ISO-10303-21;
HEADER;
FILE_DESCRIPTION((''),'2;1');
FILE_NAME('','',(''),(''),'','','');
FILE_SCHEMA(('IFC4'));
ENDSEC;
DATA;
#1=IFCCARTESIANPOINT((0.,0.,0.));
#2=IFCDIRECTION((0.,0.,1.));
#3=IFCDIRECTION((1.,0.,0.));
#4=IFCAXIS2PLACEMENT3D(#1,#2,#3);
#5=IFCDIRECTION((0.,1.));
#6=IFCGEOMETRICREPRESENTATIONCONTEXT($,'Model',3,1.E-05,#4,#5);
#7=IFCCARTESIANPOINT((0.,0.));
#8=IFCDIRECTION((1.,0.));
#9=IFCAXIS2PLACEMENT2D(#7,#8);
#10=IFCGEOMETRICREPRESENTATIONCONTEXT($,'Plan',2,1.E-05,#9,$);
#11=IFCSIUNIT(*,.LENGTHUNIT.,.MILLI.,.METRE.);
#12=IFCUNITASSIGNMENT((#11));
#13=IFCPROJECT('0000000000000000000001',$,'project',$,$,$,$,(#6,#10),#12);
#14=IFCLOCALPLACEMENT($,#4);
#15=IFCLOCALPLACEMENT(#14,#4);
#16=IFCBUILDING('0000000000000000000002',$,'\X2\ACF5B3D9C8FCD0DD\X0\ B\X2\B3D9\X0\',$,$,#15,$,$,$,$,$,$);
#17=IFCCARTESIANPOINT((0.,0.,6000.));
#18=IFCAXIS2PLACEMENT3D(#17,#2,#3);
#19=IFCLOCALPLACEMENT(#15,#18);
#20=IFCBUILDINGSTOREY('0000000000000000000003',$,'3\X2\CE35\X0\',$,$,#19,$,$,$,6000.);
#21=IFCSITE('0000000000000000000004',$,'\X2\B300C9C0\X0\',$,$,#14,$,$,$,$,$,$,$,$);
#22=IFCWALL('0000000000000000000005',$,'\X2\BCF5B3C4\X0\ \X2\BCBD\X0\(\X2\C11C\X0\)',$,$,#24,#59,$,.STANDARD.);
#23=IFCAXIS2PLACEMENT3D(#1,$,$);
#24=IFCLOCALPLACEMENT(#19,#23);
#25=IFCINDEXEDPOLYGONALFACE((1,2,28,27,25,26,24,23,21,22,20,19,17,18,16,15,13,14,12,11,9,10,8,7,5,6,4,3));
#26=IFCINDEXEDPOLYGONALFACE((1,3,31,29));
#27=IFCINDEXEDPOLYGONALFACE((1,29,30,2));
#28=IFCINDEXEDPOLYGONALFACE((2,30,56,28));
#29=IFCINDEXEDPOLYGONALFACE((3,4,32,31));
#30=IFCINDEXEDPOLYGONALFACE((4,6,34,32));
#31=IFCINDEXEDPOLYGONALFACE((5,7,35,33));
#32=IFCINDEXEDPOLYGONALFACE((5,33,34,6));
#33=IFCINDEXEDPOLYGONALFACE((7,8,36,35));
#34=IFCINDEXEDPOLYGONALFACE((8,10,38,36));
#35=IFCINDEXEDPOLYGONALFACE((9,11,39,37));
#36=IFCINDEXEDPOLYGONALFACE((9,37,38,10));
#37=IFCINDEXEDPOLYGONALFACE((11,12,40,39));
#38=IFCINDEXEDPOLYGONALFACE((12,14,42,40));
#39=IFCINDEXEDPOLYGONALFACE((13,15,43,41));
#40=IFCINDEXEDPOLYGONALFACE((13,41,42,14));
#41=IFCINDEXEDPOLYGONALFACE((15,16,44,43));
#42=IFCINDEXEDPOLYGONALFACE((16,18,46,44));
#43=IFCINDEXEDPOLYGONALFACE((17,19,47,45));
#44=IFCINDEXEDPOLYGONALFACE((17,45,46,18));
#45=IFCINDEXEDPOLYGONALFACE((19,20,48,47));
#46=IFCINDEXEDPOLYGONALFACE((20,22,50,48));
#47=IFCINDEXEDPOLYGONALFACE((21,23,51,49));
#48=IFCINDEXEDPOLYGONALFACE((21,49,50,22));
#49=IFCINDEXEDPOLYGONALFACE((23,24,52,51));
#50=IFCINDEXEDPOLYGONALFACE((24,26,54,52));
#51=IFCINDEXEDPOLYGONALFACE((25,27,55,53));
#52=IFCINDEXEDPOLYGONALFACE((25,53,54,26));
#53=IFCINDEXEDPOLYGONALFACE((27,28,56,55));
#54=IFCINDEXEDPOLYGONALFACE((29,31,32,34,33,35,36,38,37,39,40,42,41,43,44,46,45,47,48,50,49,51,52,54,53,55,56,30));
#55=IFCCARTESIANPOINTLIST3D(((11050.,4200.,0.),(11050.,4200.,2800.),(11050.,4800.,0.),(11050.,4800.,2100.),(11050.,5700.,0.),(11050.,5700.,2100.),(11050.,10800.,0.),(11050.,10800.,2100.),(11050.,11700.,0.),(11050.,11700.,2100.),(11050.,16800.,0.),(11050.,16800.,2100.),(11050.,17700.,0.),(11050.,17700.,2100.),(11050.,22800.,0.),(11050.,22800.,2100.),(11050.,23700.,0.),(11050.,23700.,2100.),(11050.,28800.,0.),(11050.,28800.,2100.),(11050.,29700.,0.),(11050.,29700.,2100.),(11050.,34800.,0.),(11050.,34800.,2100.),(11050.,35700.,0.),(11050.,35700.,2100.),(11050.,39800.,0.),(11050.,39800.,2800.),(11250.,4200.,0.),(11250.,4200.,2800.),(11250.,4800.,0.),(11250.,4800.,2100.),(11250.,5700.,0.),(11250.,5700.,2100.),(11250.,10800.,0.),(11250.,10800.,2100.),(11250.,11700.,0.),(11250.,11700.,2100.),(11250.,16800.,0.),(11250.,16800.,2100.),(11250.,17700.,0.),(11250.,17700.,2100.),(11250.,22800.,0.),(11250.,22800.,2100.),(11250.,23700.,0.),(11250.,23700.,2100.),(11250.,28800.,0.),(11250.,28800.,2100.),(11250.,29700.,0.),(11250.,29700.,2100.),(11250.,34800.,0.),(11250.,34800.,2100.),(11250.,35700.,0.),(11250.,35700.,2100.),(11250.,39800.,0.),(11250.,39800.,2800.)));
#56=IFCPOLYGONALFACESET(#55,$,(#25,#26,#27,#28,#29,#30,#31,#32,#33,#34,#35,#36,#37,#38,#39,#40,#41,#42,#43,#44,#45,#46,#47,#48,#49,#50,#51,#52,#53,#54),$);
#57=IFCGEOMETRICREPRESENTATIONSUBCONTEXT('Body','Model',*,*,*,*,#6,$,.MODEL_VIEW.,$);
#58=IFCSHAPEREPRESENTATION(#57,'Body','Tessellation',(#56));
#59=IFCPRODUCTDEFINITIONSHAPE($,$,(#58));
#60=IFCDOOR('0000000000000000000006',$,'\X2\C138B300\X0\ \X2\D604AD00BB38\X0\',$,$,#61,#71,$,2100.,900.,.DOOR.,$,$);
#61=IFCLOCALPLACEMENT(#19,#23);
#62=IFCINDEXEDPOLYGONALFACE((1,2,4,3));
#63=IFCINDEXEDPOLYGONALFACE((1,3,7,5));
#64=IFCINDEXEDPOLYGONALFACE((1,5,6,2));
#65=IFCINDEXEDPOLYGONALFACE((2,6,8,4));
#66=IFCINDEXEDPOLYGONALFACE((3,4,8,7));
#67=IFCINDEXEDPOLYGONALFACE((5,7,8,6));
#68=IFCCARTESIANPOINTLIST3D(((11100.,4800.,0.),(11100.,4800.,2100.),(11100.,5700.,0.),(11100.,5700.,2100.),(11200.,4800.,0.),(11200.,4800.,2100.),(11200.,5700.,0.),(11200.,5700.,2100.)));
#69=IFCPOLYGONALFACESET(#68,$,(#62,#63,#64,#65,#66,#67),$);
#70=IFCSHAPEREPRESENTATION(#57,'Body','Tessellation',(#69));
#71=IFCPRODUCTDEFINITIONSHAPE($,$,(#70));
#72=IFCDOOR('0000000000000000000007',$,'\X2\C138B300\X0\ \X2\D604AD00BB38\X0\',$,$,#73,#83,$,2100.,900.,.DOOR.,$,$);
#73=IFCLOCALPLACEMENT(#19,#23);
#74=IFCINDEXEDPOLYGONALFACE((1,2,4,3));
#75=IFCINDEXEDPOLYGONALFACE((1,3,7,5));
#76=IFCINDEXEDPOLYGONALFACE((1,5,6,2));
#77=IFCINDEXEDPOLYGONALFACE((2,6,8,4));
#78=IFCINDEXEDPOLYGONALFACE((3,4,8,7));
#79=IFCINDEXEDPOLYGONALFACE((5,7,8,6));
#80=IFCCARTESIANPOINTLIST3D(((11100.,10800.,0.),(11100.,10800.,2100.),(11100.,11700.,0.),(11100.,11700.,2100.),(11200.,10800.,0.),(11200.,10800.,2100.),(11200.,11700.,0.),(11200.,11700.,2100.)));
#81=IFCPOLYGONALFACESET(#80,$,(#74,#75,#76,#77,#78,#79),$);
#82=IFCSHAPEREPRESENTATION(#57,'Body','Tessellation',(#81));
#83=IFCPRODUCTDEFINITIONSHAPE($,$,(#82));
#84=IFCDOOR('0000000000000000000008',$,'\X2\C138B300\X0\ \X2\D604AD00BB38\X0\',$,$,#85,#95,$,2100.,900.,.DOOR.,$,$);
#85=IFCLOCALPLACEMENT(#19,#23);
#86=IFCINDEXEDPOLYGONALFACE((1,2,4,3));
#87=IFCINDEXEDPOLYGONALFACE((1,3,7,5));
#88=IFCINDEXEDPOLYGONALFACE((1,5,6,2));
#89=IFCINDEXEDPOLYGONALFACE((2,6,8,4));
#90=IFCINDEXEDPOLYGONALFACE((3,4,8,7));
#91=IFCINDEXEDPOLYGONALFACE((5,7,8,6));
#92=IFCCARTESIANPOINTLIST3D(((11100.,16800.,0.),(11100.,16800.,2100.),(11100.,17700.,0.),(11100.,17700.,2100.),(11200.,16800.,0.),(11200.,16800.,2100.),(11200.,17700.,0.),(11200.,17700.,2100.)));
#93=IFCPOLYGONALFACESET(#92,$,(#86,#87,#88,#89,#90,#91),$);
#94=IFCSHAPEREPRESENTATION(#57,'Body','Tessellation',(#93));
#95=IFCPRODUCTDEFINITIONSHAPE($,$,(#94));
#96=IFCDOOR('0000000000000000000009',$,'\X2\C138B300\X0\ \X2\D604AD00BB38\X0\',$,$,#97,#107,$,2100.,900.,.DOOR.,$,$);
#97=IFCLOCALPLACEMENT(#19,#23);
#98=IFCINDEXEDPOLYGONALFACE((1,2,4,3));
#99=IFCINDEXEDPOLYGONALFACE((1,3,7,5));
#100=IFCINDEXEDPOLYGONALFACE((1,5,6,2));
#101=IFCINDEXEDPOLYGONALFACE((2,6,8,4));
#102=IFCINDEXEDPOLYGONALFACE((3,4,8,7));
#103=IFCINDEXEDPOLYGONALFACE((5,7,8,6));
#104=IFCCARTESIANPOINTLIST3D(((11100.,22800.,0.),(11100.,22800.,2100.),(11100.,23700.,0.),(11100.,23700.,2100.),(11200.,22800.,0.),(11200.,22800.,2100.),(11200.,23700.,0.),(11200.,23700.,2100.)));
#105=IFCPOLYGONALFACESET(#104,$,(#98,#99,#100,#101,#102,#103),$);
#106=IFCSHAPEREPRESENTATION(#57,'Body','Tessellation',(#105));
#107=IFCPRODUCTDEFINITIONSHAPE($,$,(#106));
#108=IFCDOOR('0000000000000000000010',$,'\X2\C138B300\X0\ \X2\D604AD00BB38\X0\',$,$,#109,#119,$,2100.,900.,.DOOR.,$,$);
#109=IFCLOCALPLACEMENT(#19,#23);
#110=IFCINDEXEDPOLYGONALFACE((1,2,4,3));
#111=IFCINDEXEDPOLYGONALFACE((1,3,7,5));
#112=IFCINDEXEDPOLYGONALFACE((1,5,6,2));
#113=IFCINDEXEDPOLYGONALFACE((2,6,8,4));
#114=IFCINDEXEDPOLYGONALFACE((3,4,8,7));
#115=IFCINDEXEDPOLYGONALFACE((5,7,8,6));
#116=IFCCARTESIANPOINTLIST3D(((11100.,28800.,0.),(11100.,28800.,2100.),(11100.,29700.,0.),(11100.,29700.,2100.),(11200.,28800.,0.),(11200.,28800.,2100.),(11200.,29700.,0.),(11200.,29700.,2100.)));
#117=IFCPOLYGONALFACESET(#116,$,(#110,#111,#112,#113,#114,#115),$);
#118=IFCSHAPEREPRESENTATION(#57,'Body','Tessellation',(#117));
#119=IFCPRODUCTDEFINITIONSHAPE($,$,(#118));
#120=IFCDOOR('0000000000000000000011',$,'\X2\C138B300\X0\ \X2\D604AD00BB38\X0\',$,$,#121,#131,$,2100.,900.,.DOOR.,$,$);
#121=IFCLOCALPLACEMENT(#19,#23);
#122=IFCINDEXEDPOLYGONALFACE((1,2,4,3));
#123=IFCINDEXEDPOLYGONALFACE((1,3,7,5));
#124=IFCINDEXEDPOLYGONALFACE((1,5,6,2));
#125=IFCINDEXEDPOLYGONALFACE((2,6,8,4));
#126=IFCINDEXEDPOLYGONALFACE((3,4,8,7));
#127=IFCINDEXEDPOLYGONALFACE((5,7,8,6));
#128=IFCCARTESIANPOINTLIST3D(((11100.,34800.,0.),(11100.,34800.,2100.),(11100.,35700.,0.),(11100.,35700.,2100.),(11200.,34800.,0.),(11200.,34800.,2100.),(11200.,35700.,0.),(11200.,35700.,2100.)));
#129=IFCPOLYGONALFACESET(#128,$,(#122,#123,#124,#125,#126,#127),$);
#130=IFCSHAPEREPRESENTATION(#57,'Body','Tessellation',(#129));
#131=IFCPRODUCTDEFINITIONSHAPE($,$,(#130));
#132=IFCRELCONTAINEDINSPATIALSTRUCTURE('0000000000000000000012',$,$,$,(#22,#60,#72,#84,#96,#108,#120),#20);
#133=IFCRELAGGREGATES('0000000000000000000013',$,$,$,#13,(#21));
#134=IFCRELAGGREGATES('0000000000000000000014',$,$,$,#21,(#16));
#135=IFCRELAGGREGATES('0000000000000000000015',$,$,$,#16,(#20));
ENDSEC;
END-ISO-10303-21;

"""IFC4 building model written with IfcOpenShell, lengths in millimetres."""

from ifc_helpers import new_model, si_unit, direction, frame, origin_with_axes, origin_2d_with_axis, place, context, subcontext, project, spatial, polyline, outline, extrude, element, fill, save


model = new_model("IFC4")

# Units and contexts
model_context = context("Model", 3, precision=1e-05, world=origin_with_axes(), true_north=direction((0.0, 1.0)))
plan_context = context("Plan", 2, precision=1e-05, world=origin_2d_with_axis())
body_context = subcontext(model_context, "Body", "Model", "MODEL_VIEW")
ifc_project = project(units=[si_unit("LENGTHUNIT", "METRE", prefix="MILLI")], contexts=[model_context, plan_context])

# Site, building, storey
site_placement = place(None, origin_with_axes())
site = spatial("IfcSite", under=ifc_project, at=site_placement, Name="대지")
building_placement = place(site_placement, origin_with_axes())
building = spatial("IfcBuilding", under=site, at=building_placement, Name="공동주택 B동")
storey_placement = place(building_placement, frame((0.0, 0.0, 6000.0), z_axis=(0.0, 0.0, 1.0), x_axis=(1.0, 0.0, 0.0)))
storey = spatial("IfcBuildingStorey", under=building, at=storey_placement, Name="3층", Elevation=6000.0)

# Wall, openings, doors
wall_1_placement = place(storey_placement, origin_with_axes())
wall_1 = element("IfcWall", 1, at=wall_1_placement, inside=storey, Name="복도 벽(서)", PredefinedType="STANDARD", context=body_context, shape_type="SweptSolid", body=[
    extrude(outline(polyline([(11050.0, 4200.0), (11050.0, 39800.0), (11250.0, 39800.0), (11250.0, 4200.0), (11050.0, 4200.0)])), origin_with_axes(), (0.0, 0.0, 1.0), 2800.0),
])
opening_1_placement = place(storey_placement, origin_with_axes())
opening_1 = element("IfcOpeningElement", 2, at=opening_1_placement, cuts=wall_1, PredefinedType="OPENING", context=body_context, shape_type="SweptSolid", body=[
    extrude(outline(polyline([(11300.0, 4800.0), (11300.0, 5700.0), (11000.0, 5700.0), (11000.0, 4800.0), (11300.0, 4800.0)])), origin_with_axes(), (0.0, 0.0, 1.0), 2100.0),
])
opening_2_placement = place(storey_placement, origin_with_axes())
opening_2 = element("IfcOpeningElement", 3, at=opening_2_placement, cuts=wall_1, PredefinedType="OPENING", context=body_context, shape_type="SweptSolid", body=[
    extrude(outline(polyline([(11300.0, 10800.0), (11300.0, 11700.0), (11000.0, 11700.0), (11000.0, 10800.0), (11300.0, 10800.0)])), origin_with_axes(), (0.0, 0.0, 1.0), 2100.0),
])
opening_3_placement = place(storey_placement, origin_with_axes())
opening_3 = element("IfcOpeningElement", 4, at=opening_3_placement, cuts=wall_1, PredefinedType="OPENING", context=body_context, shape_type="SweptSolid", body=[
    extrude(outline(polyline([(11300.0, 16800.0), (11300.0, 17700.0), (11000.0, 17700.0), (11000.0, 16800.0), (11300.0, 16800.0)])), origin_with_axes(), (0.0, 0.0, 1.0), 2100.0),
])
opening_4_placement = place(storey_placement, origin_with_axes())
opening_4 = element("IfcOpeningElement", 5, at=opening_4_placement, cuts=wall_1, PredefinedType="OPENING", context=body_context, shape_type="SweptSolid", body=[
    extrude(outline(polyline([(11300.0, 22800.0), (11300.0, 23700.0), (11000.0, 23700.0), (11000.0, 22800.0), (11300.0, 22800.0)])), origin_with_axes(), (0.0, 0.0, 1.0), 2100.0),
])
opening_5_placement = place(storey_placement, origin_with_axes())
opening_5 = element("IfcOpeningElement", 6, at=opening_5_placement, cuts=wall_1, PredefinedType="OPENING", context=body_context, shape_type="SweptSolid", body=[
    extrude(outline(polyline([(11300.0, 28800.0), (11300.0, 29700.0), (11000.0, 29700.0), (11000.0, 28800.0), (11300.0, 28800.0)])), origin_with_axes(), (0.0, 0.0, 1.0), 2100.0),
])
opening_6_placement = place(storey_placement, origin_with_axes())
opening_6 = element("IfcOpeningElement", 7, at=opening_6_placement, cuts=wall_1, PredefinedType="OPENING", context=body_context, shape_type="SweptSolid", body=[
    extrude(outline(polyline([(11300.0, 34800.0), (11300.0, 35700.0), (11000.0, 35700.0), (11000.0, 34800.0), (11300.0, 34800.0)])), origin_with_axes(), (0.0, 0.0, 1.0), 2100.0),
])
door_1_placement = place(storey_placement, origin_with_axes())
door_1 = element("IfcDoor", 8, at=door_1_placement, inside=storey, Name="세대 현관문", OverallHeight=2100.0, OverallWidth=900.0, PredefinedType="DOOR", context=body_context, shape_type="SweptSolid", body=[
    extrude(outline(polyline([(11200.0, 4800.0), (11200.0, 5700.0), (11100.0, 5700.0), (11100.0, 4800.0), (11200.0, 4800.0)])), origin_with_axes(), (0.0, 0.0, 1.0), 2100.0),
])
fill(opening_1, door_1)
door_2_placement = place(storey_placement, origin_with_axes())
door_2 = element("IfcDoor", 9, at=door_2_placement, inside=storey, Name="세대 현관문", OverallHeight=2100.0, OverallWidth=900.0, PredefinedType="DOOR", context=body_context, shape_type="SweptSolid", body=[
    extrude(outline(polyline([(11200.0, 10800.0), (11200.0, 11700.0), (11100.0, 11700.0), (11100.0, 10800.0), (11200.0, 10800.0)])), origin_with_axes(), (0.0, 0.0, 1.0), 2100.0),
])
fill(opening_2, door_2)
door_3_placement = place(storey_placement, origin_with_axes())
door_3 = element("IfcDoor", 10, at=door_3_placement, inside=storey, Name="세대 현관문", OverallHeight=2100.0, OverallWidth=900.0, PredefinedType="DOOR", context=body_context, shape_type="SweptSolid", body=[
    extrude(outline(polyline([(11200.0, 16800.0), (11200.0, 17700.0), (11100.0, 17700.0), (11100.0, 16800.0), (11200.0, 16800.0)])), origin_with_axes(), (0.0, 0.0, 1.0), 2100.0),
])
fill(opening_3, door_3)
door_4_placement = place(storey_placement, origin_with_axes())
door_4 = element("IfcDoor", 11, at=door_4_placement, inside=storey, Name="세대 현관문", OverallHeight=2100.0, OverallWidth=900.0, PredefinedType="DOOR", context=body_context, shape_type="SweptSolid", body=[
    extrude(outline(polyline([(11200.0, 22800.0), (11200.0, 23700.0), (11100.0, 23700.0), (11100.0, 22800.0), (11200.0, 22800.0)])), origin_with_axes(), (0.0, 0.0, 1.0), 2100.0),
])
fill(opening_4, door_4)
door_5_placement = place(storey_placement, origin_with_axes())
door_5 = element("IfcDoor", 12, at=door_5_placement, inside=storey, Name="세대 현관문", OverallHeight=2100.0, OverallWidth=900.0, PredefinedType="DOOR", context=body_context, shape_type="SweptSolid", body=[
    extrude(outline(polyline([(11200.0, 28800.0), (11200.0, 29700.0), (11100.0, 29700.0), (11100.0, 28800.0), (11200.0, 28800.0)])), origin_with_axes(), (0.0, 0.0, 1.0), 2100.0),
])
fill(opening_5, door_5)
door_6_placement = place(storey_placement, origin_with_axes())
door_6 = element("IfcDoor", 13, at=door_6_placement, inside=storey, Name="세대 현관문", OverallHeight=2100.0, OverallWidth=900.0, PredefinedType="DOOR", context=body_context, shape_type="SweptSolid", body=[
    extrude(outline(polyline([(11200.0, 34800.0), (11200.0, 35700.0), (11100.0, 35700.0), (11100.0, 34800.0), (11200.0, 34800.0)])), origin_with_axes(), (0.0, 0.0, 1.0), 2100.0),
])
fill(opening_6, door_6)

save(model, "model.ifc")
